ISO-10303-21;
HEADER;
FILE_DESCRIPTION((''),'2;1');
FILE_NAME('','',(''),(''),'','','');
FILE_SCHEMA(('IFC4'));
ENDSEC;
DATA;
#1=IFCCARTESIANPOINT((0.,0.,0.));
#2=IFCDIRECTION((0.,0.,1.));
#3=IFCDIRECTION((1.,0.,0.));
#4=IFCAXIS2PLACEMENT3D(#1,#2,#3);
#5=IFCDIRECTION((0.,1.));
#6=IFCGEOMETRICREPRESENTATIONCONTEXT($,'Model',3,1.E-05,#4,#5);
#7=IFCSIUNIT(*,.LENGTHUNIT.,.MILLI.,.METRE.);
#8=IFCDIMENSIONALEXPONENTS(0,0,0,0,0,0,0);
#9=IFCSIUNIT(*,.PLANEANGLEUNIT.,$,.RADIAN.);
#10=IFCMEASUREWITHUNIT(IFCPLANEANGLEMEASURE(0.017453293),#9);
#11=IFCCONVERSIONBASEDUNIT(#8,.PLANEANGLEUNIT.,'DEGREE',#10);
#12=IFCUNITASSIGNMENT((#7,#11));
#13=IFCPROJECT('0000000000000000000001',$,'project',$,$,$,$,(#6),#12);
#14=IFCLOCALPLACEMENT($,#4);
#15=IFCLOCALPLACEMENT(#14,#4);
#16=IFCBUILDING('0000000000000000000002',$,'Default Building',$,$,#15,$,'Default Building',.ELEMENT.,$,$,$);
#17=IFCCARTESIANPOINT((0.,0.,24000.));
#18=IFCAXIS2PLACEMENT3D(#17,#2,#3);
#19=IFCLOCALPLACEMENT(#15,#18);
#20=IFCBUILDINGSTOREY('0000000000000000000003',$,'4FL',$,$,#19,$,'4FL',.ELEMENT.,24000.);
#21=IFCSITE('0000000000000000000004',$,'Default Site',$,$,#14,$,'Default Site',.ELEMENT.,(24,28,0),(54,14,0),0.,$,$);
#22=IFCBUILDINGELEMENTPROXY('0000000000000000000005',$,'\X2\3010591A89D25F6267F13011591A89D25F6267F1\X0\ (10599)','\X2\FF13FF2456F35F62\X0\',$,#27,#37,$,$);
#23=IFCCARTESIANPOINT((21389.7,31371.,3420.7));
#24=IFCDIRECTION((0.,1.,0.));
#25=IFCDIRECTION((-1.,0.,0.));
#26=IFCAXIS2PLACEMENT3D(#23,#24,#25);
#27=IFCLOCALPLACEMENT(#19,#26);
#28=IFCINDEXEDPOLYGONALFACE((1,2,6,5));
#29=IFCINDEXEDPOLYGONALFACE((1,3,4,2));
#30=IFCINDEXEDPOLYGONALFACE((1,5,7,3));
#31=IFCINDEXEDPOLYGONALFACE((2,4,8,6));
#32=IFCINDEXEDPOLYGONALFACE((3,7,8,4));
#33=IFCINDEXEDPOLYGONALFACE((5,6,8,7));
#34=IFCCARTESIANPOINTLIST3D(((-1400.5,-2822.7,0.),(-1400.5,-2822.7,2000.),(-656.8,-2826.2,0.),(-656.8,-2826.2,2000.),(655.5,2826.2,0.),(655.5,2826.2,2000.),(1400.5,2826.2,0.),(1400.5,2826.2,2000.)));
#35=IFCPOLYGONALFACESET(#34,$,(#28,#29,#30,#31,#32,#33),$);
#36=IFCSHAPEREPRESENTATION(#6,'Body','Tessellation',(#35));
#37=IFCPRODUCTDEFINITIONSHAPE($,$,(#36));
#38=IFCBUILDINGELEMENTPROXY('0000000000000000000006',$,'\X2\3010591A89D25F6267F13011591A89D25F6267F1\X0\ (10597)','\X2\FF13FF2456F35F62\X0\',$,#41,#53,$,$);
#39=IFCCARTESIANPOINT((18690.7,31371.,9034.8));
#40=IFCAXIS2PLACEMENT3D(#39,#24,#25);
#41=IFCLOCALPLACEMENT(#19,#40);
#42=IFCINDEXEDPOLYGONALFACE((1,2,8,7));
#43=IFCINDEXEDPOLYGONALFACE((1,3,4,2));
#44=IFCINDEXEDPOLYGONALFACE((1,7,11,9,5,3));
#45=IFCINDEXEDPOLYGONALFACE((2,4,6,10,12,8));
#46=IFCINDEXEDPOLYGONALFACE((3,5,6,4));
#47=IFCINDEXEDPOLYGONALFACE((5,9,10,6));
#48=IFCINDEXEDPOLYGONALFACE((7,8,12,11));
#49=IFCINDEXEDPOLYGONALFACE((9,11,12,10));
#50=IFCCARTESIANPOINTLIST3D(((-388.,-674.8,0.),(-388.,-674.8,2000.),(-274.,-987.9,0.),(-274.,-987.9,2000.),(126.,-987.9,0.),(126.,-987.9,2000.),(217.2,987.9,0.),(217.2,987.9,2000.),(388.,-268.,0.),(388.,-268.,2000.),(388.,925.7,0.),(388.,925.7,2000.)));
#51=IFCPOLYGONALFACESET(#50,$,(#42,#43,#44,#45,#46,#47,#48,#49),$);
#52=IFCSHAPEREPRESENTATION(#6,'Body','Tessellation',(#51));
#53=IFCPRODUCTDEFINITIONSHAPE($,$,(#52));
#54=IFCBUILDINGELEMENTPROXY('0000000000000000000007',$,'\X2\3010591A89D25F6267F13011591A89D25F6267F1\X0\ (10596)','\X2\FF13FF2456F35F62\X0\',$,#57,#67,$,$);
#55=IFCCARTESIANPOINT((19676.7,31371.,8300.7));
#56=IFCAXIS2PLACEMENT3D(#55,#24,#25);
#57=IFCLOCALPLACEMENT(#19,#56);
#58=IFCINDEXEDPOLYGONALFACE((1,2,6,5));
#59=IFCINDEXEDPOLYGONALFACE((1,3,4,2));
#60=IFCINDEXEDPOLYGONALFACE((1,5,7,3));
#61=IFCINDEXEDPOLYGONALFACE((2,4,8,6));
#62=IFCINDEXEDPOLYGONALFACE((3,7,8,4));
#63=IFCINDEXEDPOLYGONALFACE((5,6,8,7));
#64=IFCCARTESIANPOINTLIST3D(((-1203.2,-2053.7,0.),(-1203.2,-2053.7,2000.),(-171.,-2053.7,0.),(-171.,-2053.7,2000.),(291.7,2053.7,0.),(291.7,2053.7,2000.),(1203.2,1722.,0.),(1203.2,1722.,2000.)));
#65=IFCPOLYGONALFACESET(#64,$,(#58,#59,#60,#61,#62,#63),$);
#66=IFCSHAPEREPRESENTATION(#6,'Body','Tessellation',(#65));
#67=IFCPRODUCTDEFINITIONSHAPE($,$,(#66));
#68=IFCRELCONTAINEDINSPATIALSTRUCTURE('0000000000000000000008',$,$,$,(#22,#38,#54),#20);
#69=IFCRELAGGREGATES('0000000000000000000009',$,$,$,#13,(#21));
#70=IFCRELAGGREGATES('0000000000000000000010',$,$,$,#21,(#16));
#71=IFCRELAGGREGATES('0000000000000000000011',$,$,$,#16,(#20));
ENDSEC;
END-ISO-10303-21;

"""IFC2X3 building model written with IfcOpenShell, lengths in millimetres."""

from ifc_helpers import new_model, entity, si_unit, converted_unit, direction, frame, origin_with_axes, place, context, project, spatial, polyline, outline, extrude, source, transform, mapped, element, save


model = new_model("IFC2X3")

# Units and contexts
model_context = context("Model", 3, precision=1e-05, world=origin_with_axes(), true_north=direction((0.0, 1.0)))
ifc_project = project(units=[si_unit("LENGTHUNIT", "METRE", prefix="MILLI"), converted_unit("PLANEANGLEUNIT", "DEGREE", entity("IfcPlaneAngleMeasure", 0.017453293), si_unit("PLANEANGLEUNIT", "RADIAN"), dimensions=[0, 0, 0, 0, 0, 0, 0])], contexts=[model_context])

# Site, building, storey
site_placement = place(None, origin_with_axes())
site = spatial("IfcSite", under=ifc_project, at=site_placement, Name="Default Site", LongName="Default Site", CompositionType="ELEMENT", RefLatitude=(24, 28, 0), RefLongitude=(54, 14, 0), RefElevation=0.0)
building_placement = place(site_placement, origin_with_axes())
building = spatial("IfcBuilding", under=site, at=building_placement, Name="Default Building", LongName="Default Building", CompositionType="ELEMENT")
storey_placement = place(building_placement, frame((0.0, 0.0, 24000.0), z_axis=(0.0, 0.0, 1.0), x_axis=(1.0, 0.0, 0.0)))
storey = spatial("IfcBuildingStorey", under=building, at=storey_placement, Name="4FL", LongName="4FL", CompositionType="ELEMENT", Elevation=24000.0)

# Building element proxies
shared_shape_1 = source(origin_with_axes(), model_context, "Body", "SweptSolid", [
    extrude(outline(polyline([(655.5, 2826.2), (-1400.5, -2822.7), (-656.8, -2826.2), (1400.5, 2826.2), (655.5, 2826.2)])), frame((0.0, 0.0, 0.0), z_axis=(0.0, 0.0, 1.0), x_axis=(1.0, 0.0, 0.0)), (0.0, 0.0, 1.0), 2000.0),
])
proxy_1_placement = place(storey_placement, frame((21389.7, 31371.0, 3420.7), z_axis=(0.0, 1.0, 0.0), x_axis=(-1.0, 0.0, 0.0)))
element("IfcBuildingElementProxy", 1, at=proxy_1_placement, inside=storey, Name="【多角形柱】多角形柱 (10599)", Description="３Ｄ図形", context=model_context, shape_type="MappedRepresentation", body=[
    mapped(shared_shape_1, transform((0.0, 0.0, 0.0))),
])
shared_shape_2 = source(origin_with_axes(), model_context, "Body", "SweptSolid", [
    extrude(outline(polyline([(-388.0, -674.8), (-274.0, -987.9), (126.0, -987.9), (388.0, -268.0), (388.0, 925.7), (217.2, 987.9), (-388.0, -674.8)])), frame((0.0, 0.0, 0.0), z_axis=(0.0, 0.0, 1.0), x_axis=(1.0, 0.0, 0.0)), (0.0, 0.0, 1.0), 2000.0),
])
proxy_2_placement = place(storey_placement, frame((18690.7, 31371.0, 9034.8), z_axis=(0.0, 1.0, 0.0), x_axis=(-1.0, 0.0, 0.0)))
element("IfcBuildingElementProxy", 2, at=proxy_2_placement, inside=storey, Name="【多角形柱】多角形柱 (10597)", Description="３Ｄ図形", context=model_context, shape_type="MappedRepresentation", body=[
    mapped(shared_shape_2, transform((0.0, 0.0, 0.0))),
])
shared_shape_3 = source(origin_with_axes(), model_context, "Body", "SweptSolid", [
    extrude(outline(polyline([(291.7, 2053.7), (-1203.2, -2053.7), (-171.0, -2053.7), (1203.2, 1722.0), (291.7, 2053.7)])), frame((0.0, 0.0, 0.0), z_axis=(0.0, 0.0, 1.0), x_axis=(1.0, 0.0, 0.0)), (0.0, 0.0, 1.0), 2000.0),
])
proxy_3_placement = place(storey_placement, frame((19676.7, 31371.0, 8300.7), z_axis=(0.0, 1.0, 0.0), x_axis=(-1.0, 0.0, 0.0)))
element("IfcBuildingElementProxy", 3, at=proxy_3_placement, inside=storey, Name="【多角形柱】多角形柱 (10596)", Description="３Ｄ図形", context=model_context, shape_type="MappedRepresentation", body=[
    mapped(shared_shape_3, transform((0.0, 0.0, 0.0))),
])

save(model, "model.ifc")
